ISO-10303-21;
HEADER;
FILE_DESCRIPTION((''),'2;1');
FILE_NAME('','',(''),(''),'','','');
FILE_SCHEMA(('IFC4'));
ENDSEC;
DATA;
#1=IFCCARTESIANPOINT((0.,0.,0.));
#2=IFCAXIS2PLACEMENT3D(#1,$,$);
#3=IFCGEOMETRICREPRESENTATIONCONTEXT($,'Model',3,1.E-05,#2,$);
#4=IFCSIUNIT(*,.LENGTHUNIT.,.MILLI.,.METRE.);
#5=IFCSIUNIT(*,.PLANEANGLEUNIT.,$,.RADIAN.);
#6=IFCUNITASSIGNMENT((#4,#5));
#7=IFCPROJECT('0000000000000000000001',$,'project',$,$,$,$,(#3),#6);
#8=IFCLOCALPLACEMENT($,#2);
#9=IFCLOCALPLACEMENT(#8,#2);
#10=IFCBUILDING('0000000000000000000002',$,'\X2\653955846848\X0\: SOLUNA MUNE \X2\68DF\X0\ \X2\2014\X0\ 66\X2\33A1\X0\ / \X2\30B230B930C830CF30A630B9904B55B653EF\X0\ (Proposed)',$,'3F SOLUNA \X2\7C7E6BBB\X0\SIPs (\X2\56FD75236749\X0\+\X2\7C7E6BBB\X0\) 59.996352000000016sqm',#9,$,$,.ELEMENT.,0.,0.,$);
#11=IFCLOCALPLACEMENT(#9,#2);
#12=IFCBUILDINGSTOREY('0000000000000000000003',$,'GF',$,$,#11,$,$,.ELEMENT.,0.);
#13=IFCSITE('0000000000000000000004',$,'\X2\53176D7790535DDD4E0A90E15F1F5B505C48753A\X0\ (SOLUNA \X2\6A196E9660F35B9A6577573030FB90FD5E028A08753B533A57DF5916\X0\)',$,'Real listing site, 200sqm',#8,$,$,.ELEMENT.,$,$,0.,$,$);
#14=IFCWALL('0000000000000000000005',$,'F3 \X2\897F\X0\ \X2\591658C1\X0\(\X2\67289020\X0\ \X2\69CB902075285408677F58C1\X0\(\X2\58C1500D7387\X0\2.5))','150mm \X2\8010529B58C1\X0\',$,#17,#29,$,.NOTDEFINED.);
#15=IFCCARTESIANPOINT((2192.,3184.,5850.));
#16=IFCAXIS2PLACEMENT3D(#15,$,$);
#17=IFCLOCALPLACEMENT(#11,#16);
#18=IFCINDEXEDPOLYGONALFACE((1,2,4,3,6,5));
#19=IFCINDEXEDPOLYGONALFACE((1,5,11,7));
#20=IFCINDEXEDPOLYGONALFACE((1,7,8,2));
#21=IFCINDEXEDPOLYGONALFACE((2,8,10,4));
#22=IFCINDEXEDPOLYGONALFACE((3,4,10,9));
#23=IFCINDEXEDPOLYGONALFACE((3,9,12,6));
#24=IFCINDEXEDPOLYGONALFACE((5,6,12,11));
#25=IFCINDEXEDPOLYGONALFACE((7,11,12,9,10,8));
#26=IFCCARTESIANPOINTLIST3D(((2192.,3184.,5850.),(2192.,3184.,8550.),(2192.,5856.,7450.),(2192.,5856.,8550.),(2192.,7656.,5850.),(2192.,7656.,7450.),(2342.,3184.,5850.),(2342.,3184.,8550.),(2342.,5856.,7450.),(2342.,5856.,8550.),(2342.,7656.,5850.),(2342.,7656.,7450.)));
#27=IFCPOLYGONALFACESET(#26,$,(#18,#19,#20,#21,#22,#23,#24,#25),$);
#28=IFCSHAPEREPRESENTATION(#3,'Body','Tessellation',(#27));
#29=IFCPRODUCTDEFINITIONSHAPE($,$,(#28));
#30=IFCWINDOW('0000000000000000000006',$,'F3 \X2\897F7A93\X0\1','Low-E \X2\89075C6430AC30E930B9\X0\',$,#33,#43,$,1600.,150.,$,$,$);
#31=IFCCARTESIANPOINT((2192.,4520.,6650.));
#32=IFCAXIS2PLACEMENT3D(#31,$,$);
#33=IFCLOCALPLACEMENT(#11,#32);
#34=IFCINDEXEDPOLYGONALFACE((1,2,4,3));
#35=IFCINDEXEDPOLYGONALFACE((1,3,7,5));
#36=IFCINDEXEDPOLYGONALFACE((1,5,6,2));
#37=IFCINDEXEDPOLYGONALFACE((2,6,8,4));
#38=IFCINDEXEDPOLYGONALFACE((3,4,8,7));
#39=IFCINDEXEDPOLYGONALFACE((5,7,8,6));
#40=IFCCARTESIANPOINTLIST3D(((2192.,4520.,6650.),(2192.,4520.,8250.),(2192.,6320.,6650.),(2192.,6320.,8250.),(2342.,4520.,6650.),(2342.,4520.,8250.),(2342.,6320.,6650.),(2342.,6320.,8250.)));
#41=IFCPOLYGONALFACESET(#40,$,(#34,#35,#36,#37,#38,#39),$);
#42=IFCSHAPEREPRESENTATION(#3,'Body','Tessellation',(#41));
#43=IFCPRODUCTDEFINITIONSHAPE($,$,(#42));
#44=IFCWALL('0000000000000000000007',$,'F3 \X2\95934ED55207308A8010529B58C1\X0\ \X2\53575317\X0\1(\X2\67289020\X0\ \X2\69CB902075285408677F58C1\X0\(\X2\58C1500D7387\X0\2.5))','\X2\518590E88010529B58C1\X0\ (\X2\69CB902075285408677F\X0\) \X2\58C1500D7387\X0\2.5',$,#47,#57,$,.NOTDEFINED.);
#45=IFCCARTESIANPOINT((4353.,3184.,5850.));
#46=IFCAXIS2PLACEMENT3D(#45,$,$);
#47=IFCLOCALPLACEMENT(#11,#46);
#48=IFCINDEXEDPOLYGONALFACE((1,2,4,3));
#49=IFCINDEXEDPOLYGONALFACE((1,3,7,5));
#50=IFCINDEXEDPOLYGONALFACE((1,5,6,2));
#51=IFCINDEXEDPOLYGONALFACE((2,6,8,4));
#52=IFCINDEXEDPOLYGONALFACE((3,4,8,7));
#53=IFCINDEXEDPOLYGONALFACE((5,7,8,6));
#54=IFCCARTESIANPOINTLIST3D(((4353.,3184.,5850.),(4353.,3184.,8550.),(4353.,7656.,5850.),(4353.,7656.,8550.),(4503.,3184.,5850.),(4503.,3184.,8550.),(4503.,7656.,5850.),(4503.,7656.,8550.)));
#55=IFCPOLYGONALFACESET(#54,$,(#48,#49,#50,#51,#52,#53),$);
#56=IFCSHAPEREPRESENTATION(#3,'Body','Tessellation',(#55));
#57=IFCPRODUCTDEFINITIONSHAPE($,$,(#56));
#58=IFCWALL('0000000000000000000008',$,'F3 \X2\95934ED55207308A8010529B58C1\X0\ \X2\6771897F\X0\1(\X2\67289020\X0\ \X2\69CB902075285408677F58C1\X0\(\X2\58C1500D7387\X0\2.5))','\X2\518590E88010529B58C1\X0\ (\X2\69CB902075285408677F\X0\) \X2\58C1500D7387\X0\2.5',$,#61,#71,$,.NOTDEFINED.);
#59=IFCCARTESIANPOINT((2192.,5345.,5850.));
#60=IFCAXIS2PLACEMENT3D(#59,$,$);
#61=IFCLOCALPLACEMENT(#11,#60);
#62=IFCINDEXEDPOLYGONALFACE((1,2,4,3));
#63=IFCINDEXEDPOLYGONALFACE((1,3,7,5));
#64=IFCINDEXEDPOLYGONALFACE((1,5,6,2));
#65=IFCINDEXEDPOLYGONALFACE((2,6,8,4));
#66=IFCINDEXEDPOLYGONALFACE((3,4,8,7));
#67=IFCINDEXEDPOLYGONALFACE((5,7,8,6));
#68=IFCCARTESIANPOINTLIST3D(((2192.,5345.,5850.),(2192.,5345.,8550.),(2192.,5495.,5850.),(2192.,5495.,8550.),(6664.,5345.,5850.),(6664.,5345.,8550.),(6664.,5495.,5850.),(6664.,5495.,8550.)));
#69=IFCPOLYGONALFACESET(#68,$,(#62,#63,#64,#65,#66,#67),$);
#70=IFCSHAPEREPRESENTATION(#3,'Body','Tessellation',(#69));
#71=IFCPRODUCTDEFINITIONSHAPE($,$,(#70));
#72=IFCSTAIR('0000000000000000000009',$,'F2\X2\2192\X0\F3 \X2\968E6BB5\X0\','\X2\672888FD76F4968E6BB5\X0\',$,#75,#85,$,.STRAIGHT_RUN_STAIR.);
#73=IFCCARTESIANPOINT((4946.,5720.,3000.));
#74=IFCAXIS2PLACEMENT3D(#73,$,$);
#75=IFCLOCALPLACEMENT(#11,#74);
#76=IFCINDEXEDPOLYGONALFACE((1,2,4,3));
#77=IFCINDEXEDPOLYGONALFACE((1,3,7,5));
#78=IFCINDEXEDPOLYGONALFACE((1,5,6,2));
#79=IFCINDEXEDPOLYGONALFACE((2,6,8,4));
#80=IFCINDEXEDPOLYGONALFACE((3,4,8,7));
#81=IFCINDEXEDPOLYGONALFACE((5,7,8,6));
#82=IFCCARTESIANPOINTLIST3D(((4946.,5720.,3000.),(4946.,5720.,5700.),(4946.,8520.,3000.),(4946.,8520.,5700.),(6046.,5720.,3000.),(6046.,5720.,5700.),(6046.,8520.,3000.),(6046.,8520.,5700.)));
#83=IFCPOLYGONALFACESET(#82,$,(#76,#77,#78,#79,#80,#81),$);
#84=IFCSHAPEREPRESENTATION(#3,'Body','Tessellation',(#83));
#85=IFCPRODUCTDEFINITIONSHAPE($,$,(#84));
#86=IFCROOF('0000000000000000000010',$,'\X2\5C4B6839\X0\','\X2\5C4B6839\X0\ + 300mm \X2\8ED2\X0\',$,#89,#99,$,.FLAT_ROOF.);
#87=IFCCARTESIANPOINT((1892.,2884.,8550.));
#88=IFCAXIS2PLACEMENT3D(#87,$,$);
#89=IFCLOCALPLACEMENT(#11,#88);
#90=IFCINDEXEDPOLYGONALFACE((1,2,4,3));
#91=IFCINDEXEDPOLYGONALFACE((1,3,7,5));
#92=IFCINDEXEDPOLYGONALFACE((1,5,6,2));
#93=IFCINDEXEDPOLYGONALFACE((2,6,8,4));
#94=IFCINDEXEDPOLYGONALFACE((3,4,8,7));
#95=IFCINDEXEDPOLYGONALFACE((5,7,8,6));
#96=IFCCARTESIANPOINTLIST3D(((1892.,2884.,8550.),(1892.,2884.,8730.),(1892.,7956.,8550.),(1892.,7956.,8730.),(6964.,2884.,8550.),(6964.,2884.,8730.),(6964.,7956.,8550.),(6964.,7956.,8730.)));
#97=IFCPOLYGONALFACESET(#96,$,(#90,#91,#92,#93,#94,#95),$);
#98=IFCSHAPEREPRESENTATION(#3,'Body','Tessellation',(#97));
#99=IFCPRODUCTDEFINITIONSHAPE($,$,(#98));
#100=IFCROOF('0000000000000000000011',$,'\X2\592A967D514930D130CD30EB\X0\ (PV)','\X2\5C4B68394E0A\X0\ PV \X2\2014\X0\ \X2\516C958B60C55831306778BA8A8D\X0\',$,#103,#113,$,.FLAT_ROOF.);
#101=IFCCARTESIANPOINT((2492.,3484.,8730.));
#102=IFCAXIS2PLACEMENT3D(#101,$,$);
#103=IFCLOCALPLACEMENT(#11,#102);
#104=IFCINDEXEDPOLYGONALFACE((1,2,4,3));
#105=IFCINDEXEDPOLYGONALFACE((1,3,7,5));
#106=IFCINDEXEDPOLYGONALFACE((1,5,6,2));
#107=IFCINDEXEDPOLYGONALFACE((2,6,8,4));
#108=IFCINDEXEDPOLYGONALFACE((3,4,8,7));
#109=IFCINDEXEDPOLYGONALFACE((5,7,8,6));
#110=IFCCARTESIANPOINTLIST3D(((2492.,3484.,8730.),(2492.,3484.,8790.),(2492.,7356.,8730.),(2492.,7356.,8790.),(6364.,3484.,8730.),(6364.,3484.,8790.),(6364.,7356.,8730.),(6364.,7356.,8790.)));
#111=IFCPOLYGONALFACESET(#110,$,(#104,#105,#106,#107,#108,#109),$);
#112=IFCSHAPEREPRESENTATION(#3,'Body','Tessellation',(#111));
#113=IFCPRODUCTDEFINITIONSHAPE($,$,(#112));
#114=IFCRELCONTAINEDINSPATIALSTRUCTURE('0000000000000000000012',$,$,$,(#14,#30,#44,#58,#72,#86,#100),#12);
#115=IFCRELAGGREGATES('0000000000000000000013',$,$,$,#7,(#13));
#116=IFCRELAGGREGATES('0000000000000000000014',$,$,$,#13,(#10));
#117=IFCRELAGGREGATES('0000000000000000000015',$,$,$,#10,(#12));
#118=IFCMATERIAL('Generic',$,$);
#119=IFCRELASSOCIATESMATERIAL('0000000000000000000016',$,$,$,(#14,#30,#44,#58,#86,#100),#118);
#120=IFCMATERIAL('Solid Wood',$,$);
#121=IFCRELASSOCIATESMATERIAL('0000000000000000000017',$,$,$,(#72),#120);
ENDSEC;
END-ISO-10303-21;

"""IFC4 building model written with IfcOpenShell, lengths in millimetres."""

from ifc_helpers import new_model, si_unit, frame, frame_2d, origin, place, context, project, spatial, rectangle, extrude, material, element, fill, save


model = new_model("IFC4")

# Units and contexts
model_context = context("Model", 3, precision=1e-05, world=origin())
ifc_project = project(units=[si_unit("LENGTHUNIT", "METRE", prefix="MILLI"), si_unit("PLANEANGLEUNIT", "RADIAN")], contexts=[model_context])

# Site, building, storey
site_placement = place(None, origin())
site = spatial("IfcSite", under=ifc_project, at=site_placement, Name="北海道川上郡弟子屈町 (SOLUNA 標準想定敷地・都市計画区域外)", ObjectType="Real listing site, 200sqm", CompositionType="ELEMENT", RefElevation=0.0)
building_placement = place(site_placement, origin())
building = spatial("IfcBuilding", under=site, at=building_placement, Name="改善案: SOLUNA MUNE 棟 — 66㎡ / ゲストハウス運営可 (Proposed)", ObjectType="3F SOLUNA 籾殻SIPs (国産杉+籾殻) 59.996352000000016sqm", CompositionType="ELEMENT", ElevationOfRefHeight=0.0, ElevationOfTerrain=0.0)
storey_placement = place(building_placement, origin())
storey = spatial("IfcBuildingStorey", under=building, at=storey_placement, Name="GF", CompositionType="ELEMENT", Elevation=0.0)

# Shared definitions
ifc_material_1 = material(Name="Generic")

# Wall, opening, window
wall_1_placement = place(storey_placement, frame((2192.0, 3184.0, 5850.0)))
wall_1 = element("IfcWall", 1, at=wall_1_placement, inside=storey, material=ifc_material_1, Name="F3 西 外壁(木造 構造用合板壁(壁倍率2.5))", Description="150mm 耐力壁", PredefinedType="NOTDEFINED", context=model_context, shape_type="SweptSolid", body=[
    extrude(rectangle(XDim=150.0, YDim=4472.0, at=frame_2d((75.0, 2236.0))), frame((2192.0, 3184.0, 5850.0)), (0.0, 0.0, 1.0), 2700.0),
])
opening_1_placement = place(storey_placement, frame((2192.0, 4520.0, 6650.0)))
opening_1 = element("IfcOpeningElement", 2, at=opening_1_placement, cuts=wall_1, PredefinedType="NOTDEFINED", context=model_context, shape_type="SweptSolid", body=[
    extrude(rectangle(XDim=150.0, YDim=1800.0, at=frame_2d((75.0, 900.0))), frame((2192.0, 4520.0, 6650.0)), (0.0, 0.0, 1.0), 1600.0),
])
window_1_placement = place(storey_placement, frame((2192.0, 4520.0, 6650.0)))
window_1 = element("IfcWindow", 3, at=window_1_placement, inside=storey, material=ifc_material_1, Name="F3 西窓1", Description="Low-E 複層ガラス", OverallHeight=1600.0, OverallWidth=150.0, context=model_context, shape_type="SweptSolid", body=[
    extrude(rectangle(XDim=150.0, YDim=1800.0, at=frame_2d((75.0, 900.0))), frame((2192.0, 4520.0, 6650.0)), (0.0, 0.0, 1.0), 1600.0),
])
fill(opening_1, window_1)

# Walls
wall_2_placement = place(storey_placement, frame((4353.0, 3184.0, 5850.0)))
element("IfcWall", 4, at=wall_2_placement, inside=storey, material=ifc_material_1, Name="F3 間仕切り耐力壁 南北1(木造 構造用合板壁(壁倍率2.5))", Description="内部耐力壁 (構造用合板) 壁倍率2.5", PredefinedType="NOTDEFINED", context=model_context, shape_type="SweptSolid", body=[
    extrude(rectangle(XDim=150.0, YDim=4472.0, at=frame_2d((75.0, 2236.0))), frame((4353.0, 3184.0, 5850.0)), (0.0, 0.0, 1.0), 2700.0),
])
wall_3_placement = place(storey_placement, frame((2192.0, 5345.0, 5850.0)))
element("IfcWall", 5, at=wall_3_placement, inside=storey, material=ifc_material_1, Name="F3 間仕切り耐力壁 東西1(木造 構造用合板壁(壁倍率2.5))", Description="内部耐力壁 (構造用合板) 壁倍率2.5", PredefinedType="NOTDEFINED", context=model_context, shape_type="SweptSolid", body=[
    extrude(rectangle(XDim=4472.0, YDim=150.0, at=frame_2d((2236.0, 75.0))), frame((2192.0, 5345.0, 5850.0)), (0.0, 0.0, 1.0), 2700.0),
])

# Stair
ifc_material_2 = material(Name="Solid Wood")
stair_placement = place(storey_placement, frame((4946.0, 5720.0, 3000.0)))
element("IfcStair", 6, at=stair_placement, inside=storey, material=ifc_material_2, Name="F2→F3 階段", Description="木製直階段", PredefinedType="STRAIGHT_RUN_STAIR", context=model_context, shape_type="SweptSolid", body=[
    extrude(rectangle(XDim=1100.0, YDim=2800.0, at=frame_2d((550.0, 1400.0))), frame((4946.0, 5720.0, 3000.0)), (0.0, 0.0, 1.0), 2700.0),
])

# Roofs
roof_1_placement = place(storey_placement, frame((1892.0, 2884.0, 8550.0)))
element("IfcRoof", 7, at=roof_1_placement, inside=storey, material=ifc_material_1, Name="屋根", Description="屋根 + 300mm 軒", PredefinedType="FLAT_ROOF", context=model_context, shape_type="SweptSolid", body=[
    extrude(rectangle(XDim=5072.0, YDim=5072.0, at=frame_2d((2536.0, 2536.0))), frame((1892.0, 2884.0, 8550.0)), (0.0, 0.0, 1.0), 180.0),
])
roof_2_placement = place(storey_placement, frame((2492.0, 3484.0, 8730.0)))
element("IfcRoof", 8, at=roof_2_placement, inside=storey, material=ifc_material_1, Name="太陽光パネル (PV)", Description="屋根上 PV — 公開情報で確認", PredefinedType="FLAT_ROOF", context=model_context, shape_type="SweptSolid", body=[
    extrude(rectangle(XDim=3872.0, YDim=3872.0, at=frame_2d((1936.0, 1936.0))), frame((2492.0, 3484.0, 8730.0)), (0.0, 0.0, 1.0), 60.0),
])

save(model, "model.ifc")
